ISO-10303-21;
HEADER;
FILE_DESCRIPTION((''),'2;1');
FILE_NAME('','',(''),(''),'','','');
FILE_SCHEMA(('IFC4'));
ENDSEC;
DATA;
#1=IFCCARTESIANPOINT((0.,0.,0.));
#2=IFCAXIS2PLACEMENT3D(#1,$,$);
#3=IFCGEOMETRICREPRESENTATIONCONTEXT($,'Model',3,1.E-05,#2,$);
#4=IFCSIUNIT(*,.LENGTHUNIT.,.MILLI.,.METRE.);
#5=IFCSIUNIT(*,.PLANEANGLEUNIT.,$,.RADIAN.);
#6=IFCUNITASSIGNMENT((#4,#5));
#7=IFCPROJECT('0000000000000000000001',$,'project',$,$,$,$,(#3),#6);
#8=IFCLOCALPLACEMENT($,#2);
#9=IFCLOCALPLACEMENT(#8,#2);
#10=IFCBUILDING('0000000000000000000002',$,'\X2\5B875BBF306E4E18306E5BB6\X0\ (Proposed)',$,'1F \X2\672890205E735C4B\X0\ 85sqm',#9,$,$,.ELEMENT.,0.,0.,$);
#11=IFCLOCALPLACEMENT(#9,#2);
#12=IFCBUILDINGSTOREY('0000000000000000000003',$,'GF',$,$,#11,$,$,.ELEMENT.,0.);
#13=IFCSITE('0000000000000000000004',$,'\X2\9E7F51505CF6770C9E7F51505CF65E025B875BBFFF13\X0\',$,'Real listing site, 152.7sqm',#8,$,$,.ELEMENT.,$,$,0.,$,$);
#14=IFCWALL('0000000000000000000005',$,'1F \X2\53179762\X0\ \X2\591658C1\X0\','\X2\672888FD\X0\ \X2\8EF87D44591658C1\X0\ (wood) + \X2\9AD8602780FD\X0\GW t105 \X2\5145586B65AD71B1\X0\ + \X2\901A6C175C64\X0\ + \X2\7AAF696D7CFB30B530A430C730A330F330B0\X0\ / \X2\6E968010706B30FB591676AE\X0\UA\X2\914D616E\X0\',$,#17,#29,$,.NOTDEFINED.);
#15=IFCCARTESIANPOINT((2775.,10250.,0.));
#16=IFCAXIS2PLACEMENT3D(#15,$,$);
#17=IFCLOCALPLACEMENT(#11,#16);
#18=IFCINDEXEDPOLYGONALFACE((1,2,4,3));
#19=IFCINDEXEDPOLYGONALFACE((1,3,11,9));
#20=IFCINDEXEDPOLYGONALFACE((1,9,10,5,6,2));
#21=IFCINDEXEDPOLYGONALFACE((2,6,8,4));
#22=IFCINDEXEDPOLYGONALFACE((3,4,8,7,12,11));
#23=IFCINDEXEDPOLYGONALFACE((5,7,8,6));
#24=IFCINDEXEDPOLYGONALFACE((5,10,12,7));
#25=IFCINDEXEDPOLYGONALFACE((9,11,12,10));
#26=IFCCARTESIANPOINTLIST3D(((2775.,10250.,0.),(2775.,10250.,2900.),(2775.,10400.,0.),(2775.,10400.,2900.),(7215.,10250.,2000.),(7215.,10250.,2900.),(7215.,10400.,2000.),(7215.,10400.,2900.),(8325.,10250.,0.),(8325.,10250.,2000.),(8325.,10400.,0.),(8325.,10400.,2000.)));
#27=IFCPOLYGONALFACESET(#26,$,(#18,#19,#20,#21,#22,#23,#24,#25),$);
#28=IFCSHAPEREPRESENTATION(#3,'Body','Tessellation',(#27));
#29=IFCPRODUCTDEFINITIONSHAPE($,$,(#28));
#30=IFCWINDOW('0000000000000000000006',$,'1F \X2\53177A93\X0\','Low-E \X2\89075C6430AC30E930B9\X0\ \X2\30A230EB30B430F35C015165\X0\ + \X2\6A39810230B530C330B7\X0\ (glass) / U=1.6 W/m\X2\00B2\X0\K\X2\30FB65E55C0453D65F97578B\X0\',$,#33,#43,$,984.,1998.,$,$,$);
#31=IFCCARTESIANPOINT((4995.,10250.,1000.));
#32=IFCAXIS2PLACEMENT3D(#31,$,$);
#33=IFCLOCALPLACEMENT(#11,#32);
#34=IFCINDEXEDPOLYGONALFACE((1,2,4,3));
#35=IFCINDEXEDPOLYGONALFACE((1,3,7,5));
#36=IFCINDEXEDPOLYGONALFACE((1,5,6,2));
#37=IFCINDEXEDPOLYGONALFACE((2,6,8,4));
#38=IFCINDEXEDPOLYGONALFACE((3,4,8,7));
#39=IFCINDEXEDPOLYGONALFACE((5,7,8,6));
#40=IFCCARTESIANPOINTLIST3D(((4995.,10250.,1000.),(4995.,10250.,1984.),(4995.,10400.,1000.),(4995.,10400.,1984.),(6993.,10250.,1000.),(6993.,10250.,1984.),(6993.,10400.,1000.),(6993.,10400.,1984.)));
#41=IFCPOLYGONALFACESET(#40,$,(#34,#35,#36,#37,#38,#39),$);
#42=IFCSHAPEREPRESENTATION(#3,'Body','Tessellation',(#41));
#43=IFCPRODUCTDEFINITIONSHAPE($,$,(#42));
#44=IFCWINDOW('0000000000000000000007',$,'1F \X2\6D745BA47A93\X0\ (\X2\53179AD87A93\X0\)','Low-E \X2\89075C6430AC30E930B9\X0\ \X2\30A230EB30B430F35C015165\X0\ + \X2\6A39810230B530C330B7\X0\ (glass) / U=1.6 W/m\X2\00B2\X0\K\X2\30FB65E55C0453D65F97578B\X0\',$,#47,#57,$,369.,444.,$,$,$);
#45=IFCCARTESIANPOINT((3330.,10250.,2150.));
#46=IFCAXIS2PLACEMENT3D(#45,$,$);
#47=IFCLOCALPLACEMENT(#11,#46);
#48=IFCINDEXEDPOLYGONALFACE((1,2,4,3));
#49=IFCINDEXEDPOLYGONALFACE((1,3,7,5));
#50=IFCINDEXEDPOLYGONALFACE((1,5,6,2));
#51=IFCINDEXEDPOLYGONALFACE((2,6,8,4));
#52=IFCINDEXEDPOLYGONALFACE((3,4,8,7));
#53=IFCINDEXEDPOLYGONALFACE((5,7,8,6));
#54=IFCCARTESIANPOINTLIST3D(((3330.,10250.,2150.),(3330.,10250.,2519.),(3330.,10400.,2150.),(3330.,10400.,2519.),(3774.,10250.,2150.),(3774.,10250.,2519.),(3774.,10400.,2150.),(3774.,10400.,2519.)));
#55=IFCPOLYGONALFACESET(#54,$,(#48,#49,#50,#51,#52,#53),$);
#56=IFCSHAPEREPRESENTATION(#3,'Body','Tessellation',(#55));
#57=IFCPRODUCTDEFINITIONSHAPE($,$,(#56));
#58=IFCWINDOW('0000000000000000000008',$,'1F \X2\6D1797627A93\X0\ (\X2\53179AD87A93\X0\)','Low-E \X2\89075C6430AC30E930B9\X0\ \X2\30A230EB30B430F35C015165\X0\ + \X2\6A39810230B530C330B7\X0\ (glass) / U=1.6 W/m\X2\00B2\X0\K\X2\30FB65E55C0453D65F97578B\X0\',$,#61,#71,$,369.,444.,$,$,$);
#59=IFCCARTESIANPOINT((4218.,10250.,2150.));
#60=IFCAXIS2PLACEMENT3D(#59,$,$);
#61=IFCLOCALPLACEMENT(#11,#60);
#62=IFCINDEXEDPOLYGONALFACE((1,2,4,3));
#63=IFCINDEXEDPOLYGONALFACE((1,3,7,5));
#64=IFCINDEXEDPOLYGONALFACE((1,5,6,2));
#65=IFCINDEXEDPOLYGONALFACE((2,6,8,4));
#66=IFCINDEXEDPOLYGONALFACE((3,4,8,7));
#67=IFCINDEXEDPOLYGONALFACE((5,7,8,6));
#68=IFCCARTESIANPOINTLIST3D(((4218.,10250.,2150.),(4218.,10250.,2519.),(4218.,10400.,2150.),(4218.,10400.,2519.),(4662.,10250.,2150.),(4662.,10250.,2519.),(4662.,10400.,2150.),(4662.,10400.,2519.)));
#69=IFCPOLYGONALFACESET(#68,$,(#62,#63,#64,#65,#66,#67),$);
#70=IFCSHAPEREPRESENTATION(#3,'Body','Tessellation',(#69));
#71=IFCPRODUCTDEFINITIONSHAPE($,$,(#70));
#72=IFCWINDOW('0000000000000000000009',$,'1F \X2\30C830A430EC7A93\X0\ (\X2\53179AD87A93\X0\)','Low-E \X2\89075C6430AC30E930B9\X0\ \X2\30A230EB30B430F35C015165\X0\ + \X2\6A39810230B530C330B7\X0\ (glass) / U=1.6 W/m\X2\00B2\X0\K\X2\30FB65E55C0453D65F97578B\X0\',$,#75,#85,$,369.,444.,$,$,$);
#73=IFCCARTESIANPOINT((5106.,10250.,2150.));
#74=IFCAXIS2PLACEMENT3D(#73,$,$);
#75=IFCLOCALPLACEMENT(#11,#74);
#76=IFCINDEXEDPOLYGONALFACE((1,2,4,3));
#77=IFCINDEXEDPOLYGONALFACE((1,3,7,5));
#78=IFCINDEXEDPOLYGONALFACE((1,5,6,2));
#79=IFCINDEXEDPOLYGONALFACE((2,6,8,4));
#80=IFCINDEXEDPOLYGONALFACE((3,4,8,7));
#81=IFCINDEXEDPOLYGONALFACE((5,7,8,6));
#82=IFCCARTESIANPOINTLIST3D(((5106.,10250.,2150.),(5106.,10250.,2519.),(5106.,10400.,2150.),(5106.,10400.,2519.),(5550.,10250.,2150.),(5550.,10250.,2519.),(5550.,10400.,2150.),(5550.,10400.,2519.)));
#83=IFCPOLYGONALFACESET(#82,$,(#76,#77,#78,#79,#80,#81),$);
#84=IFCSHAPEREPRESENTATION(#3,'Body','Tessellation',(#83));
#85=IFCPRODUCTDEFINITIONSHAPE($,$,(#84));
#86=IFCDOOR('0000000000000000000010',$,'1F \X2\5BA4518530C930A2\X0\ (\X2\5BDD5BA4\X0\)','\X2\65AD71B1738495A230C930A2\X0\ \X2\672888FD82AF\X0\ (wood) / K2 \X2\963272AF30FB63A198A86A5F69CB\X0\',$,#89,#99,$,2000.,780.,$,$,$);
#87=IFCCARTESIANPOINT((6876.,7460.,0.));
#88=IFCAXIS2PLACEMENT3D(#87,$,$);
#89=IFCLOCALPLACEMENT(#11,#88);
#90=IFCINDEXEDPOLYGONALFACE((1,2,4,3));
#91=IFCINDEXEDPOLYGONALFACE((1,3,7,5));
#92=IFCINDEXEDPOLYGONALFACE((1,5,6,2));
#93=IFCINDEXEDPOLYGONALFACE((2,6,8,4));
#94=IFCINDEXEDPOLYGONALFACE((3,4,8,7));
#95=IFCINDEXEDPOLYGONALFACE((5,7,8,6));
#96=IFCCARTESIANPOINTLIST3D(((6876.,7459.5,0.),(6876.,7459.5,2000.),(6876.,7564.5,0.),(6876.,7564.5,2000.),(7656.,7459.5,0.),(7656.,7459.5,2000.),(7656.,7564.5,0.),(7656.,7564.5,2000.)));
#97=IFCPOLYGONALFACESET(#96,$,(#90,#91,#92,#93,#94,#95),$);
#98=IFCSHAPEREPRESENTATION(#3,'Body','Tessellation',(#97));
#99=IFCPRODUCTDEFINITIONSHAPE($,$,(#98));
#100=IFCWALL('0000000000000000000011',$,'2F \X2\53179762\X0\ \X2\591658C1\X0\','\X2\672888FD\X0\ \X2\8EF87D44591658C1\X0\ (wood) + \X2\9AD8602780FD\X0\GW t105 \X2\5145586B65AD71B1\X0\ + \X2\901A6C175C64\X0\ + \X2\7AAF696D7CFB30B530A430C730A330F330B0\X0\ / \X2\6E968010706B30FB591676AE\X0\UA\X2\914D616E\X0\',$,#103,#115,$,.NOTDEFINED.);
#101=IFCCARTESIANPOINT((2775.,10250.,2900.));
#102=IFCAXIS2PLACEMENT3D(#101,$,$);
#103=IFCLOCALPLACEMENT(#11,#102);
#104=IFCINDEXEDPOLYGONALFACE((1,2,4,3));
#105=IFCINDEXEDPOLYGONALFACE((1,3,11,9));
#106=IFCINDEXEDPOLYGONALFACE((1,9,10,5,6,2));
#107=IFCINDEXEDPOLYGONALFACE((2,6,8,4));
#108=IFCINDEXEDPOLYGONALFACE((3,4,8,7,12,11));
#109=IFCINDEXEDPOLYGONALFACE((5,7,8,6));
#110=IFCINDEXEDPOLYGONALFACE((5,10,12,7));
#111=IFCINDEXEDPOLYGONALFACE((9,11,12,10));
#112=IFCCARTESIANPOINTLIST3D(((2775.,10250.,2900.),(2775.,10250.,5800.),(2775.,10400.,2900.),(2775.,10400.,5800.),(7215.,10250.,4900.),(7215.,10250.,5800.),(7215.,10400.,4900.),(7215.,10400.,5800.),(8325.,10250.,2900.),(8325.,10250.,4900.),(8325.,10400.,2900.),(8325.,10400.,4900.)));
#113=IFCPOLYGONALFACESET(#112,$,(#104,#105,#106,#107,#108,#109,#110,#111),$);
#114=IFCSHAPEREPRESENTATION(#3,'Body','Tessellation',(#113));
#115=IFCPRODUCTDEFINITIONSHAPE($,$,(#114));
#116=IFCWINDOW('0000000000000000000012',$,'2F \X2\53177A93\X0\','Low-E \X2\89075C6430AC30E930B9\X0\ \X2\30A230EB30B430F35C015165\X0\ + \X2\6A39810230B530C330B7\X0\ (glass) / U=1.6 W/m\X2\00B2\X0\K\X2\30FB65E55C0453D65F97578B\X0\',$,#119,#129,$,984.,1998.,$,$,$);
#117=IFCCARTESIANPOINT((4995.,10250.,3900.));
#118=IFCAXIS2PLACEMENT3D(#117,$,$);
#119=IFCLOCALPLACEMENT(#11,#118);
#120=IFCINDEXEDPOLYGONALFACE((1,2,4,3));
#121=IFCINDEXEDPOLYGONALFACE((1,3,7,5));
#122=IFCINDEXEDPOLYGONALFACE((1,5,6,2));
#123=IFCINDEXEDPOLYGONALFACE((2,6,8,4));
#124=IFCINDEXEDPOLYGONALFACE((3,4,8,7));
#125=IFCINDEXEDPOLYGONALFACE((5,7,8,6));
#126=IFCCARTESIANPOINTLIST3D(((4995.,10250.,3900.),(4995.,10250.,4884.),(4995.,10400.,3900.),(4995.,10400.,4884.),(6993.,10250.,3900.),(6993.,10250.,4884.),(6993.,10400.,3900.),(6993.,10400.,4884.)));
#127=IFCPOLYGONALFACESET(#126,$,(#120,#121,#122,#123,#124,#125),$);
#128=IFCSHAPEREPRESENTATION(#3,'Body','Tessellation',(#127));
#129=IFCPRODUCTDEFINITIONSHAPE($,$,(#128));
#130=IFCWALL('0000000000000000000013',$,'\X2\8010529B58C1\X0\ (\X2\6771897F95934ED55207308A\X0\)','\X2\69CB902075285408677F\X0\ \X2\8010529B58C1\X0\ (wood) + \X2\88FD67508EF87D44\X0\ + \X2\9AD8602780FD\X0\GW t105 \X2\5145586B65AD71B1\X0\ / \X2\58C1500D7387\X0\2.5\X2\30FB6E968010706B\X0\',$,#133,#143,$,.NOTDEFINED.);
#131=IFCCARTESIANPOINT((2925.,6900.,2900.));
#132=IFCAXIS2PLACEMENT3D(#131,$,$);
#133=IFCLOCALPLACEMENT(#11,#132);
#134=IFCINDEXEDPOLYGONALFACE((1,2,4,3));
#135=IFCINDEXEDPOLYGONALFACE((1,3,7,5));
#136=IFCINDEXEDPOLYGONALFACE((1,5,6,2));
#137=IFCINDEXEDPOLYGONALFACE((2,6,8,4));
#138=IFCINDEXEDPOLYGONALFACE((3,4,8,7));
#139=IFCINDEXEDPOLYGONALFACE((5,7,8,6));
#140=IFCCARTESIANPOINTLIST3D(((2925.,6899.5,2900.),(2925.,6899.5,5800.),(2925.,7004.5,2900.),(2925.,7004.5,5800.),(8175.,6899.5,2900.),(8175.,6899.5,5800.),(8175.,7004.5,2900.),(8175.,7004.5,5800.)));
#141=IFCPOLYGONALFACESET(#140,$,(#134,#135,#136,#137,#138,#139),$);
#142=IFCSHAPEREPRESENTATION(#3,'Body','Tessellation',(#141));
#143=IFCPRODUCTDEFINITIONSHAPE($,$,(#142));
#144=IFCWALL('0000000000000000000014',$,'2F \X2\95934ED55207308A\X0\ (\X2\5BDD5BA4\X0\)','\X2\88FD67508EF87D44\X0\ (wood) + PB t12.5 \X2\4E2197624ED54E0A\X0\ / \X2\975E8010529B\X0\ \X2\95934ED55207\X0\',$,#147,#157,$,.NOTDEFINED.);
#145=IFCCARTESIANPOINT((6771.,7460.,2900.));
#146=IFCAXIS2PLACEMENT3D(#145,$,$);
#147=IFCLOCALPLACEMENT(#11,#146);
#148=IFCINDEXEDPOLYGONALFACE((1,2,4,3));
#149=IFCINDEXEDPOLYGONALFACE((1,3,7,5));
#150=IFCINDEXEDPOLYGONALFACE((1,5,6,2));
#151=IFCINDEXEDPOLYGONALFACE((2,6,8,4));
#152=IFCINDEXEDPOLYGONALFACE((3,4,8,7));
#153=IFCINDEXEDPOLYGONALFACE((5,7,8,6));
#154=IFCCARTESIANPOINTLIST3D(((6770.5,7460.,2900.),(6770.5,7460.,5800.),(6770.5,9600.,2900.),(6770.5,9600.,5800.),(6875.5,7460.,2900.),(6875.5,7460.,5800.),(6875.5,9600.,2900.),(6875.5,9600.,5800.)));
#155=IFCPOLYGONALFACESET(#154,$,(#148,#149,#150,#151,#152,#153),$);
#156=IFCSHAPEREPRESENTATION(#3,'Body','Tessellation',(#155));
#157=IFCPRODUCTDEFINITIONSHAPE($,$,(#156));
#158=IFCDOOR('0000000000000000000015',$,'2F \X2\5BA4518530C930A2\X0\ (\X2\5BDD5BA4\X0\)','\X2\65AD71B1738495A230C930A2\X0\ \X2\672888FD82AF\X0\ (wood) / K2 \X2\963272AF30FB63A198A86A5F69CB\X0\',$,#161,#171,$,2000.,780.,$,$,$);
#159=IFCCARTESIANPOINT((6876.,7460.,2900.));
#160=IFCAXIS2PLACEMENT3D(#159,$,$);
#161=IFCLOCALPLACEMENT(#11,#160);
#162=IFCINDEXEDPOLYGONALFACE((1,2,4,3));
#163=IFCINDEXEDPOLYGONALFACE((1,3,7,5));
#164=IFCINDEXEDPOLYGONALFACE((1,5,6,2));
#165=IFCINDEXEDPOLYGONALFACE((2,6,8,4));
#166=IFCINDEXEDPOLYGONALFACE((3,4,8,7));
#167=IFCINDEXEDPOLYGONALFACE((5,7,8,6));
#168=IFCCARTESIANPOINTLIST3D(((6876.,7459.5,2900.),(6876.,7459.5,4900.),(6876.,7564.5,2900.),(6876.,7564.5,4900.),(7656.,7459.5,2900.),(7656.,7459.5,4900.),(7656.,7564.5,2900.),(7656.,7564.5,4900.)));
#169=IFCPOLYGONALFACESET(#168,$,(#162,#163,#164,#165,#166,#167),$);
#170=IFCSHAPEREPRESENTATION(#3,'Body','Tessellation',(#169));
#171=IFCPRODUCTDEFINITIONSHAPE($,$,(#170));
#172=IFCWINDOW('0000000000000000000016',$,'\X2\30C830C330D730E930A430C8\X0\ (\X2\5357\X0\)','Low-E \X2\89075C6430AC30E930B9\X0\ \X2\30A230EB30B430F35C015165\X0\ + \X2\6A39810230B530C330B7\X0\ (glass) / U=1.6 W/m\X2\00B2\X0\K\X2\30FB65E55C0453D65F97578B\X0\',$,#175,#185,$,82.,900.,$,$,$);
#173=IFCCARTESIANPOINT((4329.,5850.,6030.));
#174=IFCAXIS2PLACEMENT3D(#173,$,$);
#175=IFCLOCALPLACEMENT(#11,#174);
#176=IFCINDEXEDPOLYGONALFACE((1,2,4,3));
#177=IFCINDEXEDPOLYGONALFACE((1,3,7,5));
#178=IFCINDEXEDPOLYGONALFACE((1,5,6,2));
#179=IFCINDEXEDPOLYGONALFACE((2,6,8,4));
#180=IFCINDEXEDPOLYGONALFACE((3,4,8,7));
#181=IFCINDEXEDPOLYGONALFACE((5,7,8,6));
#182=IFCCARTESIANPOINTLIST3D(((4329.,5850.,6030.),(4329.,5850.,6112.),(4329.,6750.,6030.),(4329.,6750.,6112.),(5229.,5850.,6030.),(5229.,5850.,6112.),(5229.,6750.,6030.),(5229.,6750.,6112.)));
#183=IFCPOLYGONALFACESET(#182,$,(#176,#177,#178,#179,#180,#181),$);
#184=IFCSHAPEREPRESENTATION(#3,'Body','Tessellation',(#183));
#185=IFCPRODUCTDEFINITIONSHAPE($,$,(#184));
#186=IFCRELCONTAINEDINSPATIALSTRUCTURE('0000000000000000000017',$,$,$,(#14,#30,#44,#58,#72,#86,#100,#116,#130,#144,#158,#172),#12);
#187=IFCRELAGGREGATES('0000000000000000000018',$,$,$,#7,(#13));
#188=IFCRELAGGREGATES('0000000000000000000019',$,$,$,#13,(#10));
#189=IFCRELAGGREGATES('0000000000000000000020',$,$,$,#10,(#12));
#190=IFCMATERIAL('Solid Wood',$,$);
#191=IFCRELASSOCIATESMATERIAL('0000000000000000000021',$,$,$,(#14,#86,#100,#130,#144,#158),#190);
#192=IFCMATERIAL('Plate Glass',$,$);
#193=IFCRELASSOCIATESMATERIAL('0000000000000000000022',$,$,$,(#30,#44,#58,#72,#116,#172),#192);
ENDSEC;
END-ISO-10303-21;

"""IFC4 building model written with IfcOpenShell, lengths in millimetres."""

from ifc_helpers import new_model, si_unit, frame, frame_2d, origin, place, context, project, spatial, rectangle, extrude, material, element, fill, save


model = new_model("IFC4")

# Units and contexts
model_context = context("Model", 3, precision=1e-05, world=origin())
ifc_project = project(units=[si_unit("LENGTHUNIT", "METRE", prefix="MILLI"), si_unit("PLANEANGLEUNIT", "RADIAN")], contexts=[model_context])

# Site, building, storey
site_placement = place(None, origin())
site = spatial("IfcSite", under=ifc_project, at=site_placement, Name="鹿児島県鹿児島市宇宿３", ObjectType="Real listing site, 152.7sqm", CompositionType="ELEMENT", RefElevation=0.0)
building_placement = place(site_placement, origin())
building = spatial("IfcBuilding", under=site, at=building_placement, Name="宇宿の丘の家 (Proposed)", ObjectType="1F 木造平屋 85sqm", CompositionType="ELEMENT", ElevationOfRefHeight=0.0, ElevationOfTerrain=0.0)
storey_placement = place(building_placement, origin())
storey = spatial("IfcBuildingStorey", under=building, at=storey_placement, Name="GF", CompositionType="ELEMENT", Elevation=0.0)

# Wall, openings, windows
ifc_material_1 = material(Name="Solid Wood")
wall_1_placement = place(storey_placement, frame((2775.0, 10250.0, 0.0)))
wall_1 = element("IfcWall", 1, at=wall_1_placement, inside=storey, material=ifc_material_1, Name="1F 北面 外壁", Description="木製 軸組外壁 (wood) + 高性能GW t105 充填断熱 + 通気層 + 窯業系サイディング / 準耐火・外皮UA配慮", PredefinedType="NOTDEFINED", context=model_context, shape_type="SweptSolid", body=[
    extrude(rectangle(XDim=5550.0, YDim=150.0, at=frame_2d((2775.0, 75.0))), frame((2775.0, 10250.0, 0.0)), (0.0, 0.0, 1.0), 2900.0),
])
opening_1_placement = place(storey_placement, frame((4995.0, 10250.0, 1000.0)))
opening_1 = element("IfcOpeningElement", 2, at=opening_1_placement, cuts=wall_1, PredefinedType="NOTDEFINED", context=model_context, shape_type="SweptSolid", body=[
    extrude(rectangle(XDim=1998.0, YDim=150.0, at=frame_2d((999.0, 75.0))), frame((4995.0, 10250.0, 1000.0)), (0.0, 0.0, 1.0), 984.0),
])
opening_2_placement = place(storey_placement, frame((3330.0, 10250.0, 2150.0)))
opening_2 = element("IfcOpeningElement", 3, at=opening_2_placement, cuts=wall_1, PredefinedType="NOTDEFINED", context=model_context, shape_type="SweptSolid", body=[
    extrude(rectangle(XDim=444.0, YDim=150.0, at=frame_2d((222.0, 75.0))), frame((3330.0, 10250.0, 2150.0)), (0.0, 0.0, 1.0), 369.0),
])
opening_3_placement = place(storey_placement, frame((4218.0, 10250.0, 2150.0)))
opening_3 = element("IfcOpeningElement", 4, at=opening_3_placement, cuts=wall_1, PredefinedType="NOTDEFINED", context=model_context, shape_type="SweptSolid", body=[
    extrude(rectangle(XDim=444.0, YDim=150.0, at=frame_2d((222.0, 75.0))), frame((4218.0, 10250.0, 2150.0)), (0.0, 0.0, 1.0), 369.0),
])
opening_4_placement = place(storey_placement, frame((5106.0, 10250.0, 2150.0)))
opening_4 = element("IfcOpeningElement", 5, at=opening_4_placement, cuts=wall_1, PredefinedType="NOTDEFINED", context=model_context, shape_type="SweptSolid", body=[
    extrude(rectangle(XDim=444.0, YDim=150.0, at=frame_2d((222.0, 75.0))), frame((5106.0, 10250.0, 2150.0)), (0.0, 0.0, 1.0), 369.0),
])
ifc_material_2 = material(Name="Plate Glass")
window_1_placement = place(storey_placement, frame((4995.0, 10250.0, 1000.0)))
window_1 = element("IfcWindow", 6, at=window_1_placement, inside=storey, material=ifc_material_2, Name="1F 北窓", Description="Low-E 複層ガラス アルゴン封入 + 樹脂サッシ (glass) / U=1.6 W/m²K・日射取得型", OverallHeight=984.0, OverallWidth=1998.0, context=model_context, shape_type="SweptSolid", body=[
    extrude(rectangle(XDim=1998.0, YDim=150.0, at=frame_2d((999.0, 75.0))), frame((4995.0, 10250.0, 1000.0)), (0.0, 0.0, 1.0), 984.0),
])
fill(opening_1, window_1)
window_2_placement = place(storey_placement, frame((3330.0, 10250.0, 2150.0)))
window_2 = element("IfcWindow", 7, at=window_2_placement, inside=storey, material=ifc_material_2, Name="1F 浴室窓 (北高窓)", Description="Low-E 複層ガラス アルゴン封入 + 樹脂サッシ (glass) / U=1.6 W/m²K・日射取得型", OverallHeight=369.0, OverallWidth=444.0, context=model_context, shape_type="SweptSolid", body=[
    extrude(rectangle(XDim=444.0, YDim=150.0, at=frame_2d((222.0, 75.0))), frame((3330.0, 10250.0, 2150.0)), (0.0, 0.0, 1.0), 369.0),
])
fill(opening_2, window_2)
window_3_placement = place(storey_placement, frame((4218.0, 10250.0, 2150.0)))
window_3 = element("IfcWindow", 8, at=window_3_placement, inside=storey, material=ifc_material_2, Name="1F 洗面窓 (北高窓)", Description="Low-E 複層ガラス アルゴン封入 + 樹脂サッシ (glass) / U=1.6 W/m²K・日射取得型", OverallHeight=369.0, OverallWidth=444.0, context=model_context, shape_type="SweptSolid", body=[
    extrude(rectangle(XDim=444.0, YDim=150.0, at=frame_2d((222.0, 75.0))), frame((4218.0, 10250.0, 2150.0)), (0.0, 0.0, 1.0), 369.0),
])
fill(opening_3, window_3)
window_4_placement = place(storey_placement, frame((5106.0, 10250.0, 2150.0)))
window_4 = element("IfcWindow", 9, at=window_4_placement, inside=storey, material=ifc_material_2, Name="1F トイレ窓 (北高窓)", Description="Low-E 複層ガラス アルゴン封入 + 樹脂サッシ (glass) / U=1.6 W/m²K・日射取得型", OverallHeight=369.0, OverallWidth=444.0, context=model_context, shape_type="SweptSolid", body=[
    extrude(rectangle(XDim=444.0, YDim=150.0, at=frame_2d((222.0, 75.0))), frame((5106.0, 10250.0, 2150.0)), (0.0, 0.0, 1.0), 369.0),
])
fill(opening_4, window_4)

# Door
door_1_placement = place(storey_placement, frame((6876.0, 7460.0, 0.0)))
element("IfcDoor", 10, at=door_1_placement, inside=storey, material=ifc_material_1, Name="1F 室内ドア (寝室)", Description="断熱玄関ドア 木製芯 (wood) / K2 防犯・採風機構", OverallHeight=2000.0, OverallWidth=780.0, context=model_context, shape_type="SweptSolid", body=[
    extrude(rectangle(XDim=780.0, YDim=105.0, at=frame_2d((390.0, 52.0))), frame((6876.0, 7460.0, 0.0)), (0.0, 0.0, 1.0), 2000.0),
])

# Wall, opening, window
wall_2_placement = place(storey_placement, frame((2775.0, 10250.0, 2900.0)))
wall_2 = element("IfcWall", 11, at=wall_2_placement, inside=storey, material=ifc_material_1, Name="2F 北面 外壁", Description="木製 軸組外壁 (wood) + 高性能GW t105 充填断熱 + 通気層 + 窯業系サイディング / 準耐火・外皮UA配慮", PredefinedType="NOTDEFINED", context=model_context, shape_type="SweptSolid", body=[
    extrude(rectangle(XDim=5550.0, YDim=150.0, at=frame_2d((2775.0, 75.0))), frame((2775.0, 10250.0, 2900.0)), (0.0, 0.0, 1.0), 2900.0),
])
opening_5_placement = place(storey_placement, frame((4995.0, 10250.0, 3900.0)))
opening_5 = element("IfcOpeningElement", 12, at=opening_5_placement, cuts=wall_2, PredefinedType="NOTDEFINED", context=model_context, shape_type="SweptSolid", body=[
    extrude(rectangle(XDim=1998.0, YDim=150.0, at=frame_2d((999.0, 75.0))), frame((4995.0, 10250.0, 3900.0)), (0.0, 0.0, 1.0), 984.0),
])
window_5_placement = place(storey_placement, frame((4995.0, 10250.0, 3900.0)))
window_5 = element("IfcWindow", 13, at=window_5_placement, inside=storey, material=ifc_material_2, Name="2F 北窓", Description="Low-E 複層ガラス アルゴン封入 + 樹脂サッシ (glass) / U=1.6 W/m²K・日射取得型", OverallHeight=984.0, OverallWidth=1998.0, context=model_context, shape_type="SweptSolid", body=[
    extrude(rectangle(XDim=1998.0, YDim=150.0, at=frame_2d((999.0, 75.0))), frame((4995.0, 10250.0, 3900.0)), (0.0, 0.0, 1.0), 984.0),
])
fill(opening_5, window_5)

# Walls
wall_3_placement = place(storey_placement, frame((2925.0, 6900.0, 2900.0)))
element("IfcWall", 14, at=wall_3_placement, inside=storey, material=ifc_material_1, Name="耐力壁 (東西間仕切り)", Description="構造用合板 耐力壁 (wood) + 製材軸組 + 高性能GW t105 充填断熱 / 壁倍率2.5・準耐火", PredefinedType="NOTDEFINED", context=model_context, shape_type="SweptSolid", body=[
    extrude(rectangle(XDim=5250.0, YDim=105.0, at=frame_2d((2625.0, 52.0))), frame((2925.0, 6900.0, 2900.0)), (0.0, 0.0, 1.0), 2900.0),
])
wall_4_placement = place(storey_placement, frame((6771.0, 7460.0, 2900.0)))
element("IfcWall", 15, at=wall_4_placement, inside=storey, material=ifc_material_1, Name="2F 間仕切り (寝室)", Description="製材軸組 (wood) + PB t12.5 両面仕上 / 非耐力 間仕切", PredefinedType="NOTDEFINED", context=model_context, shape_type="SweptSolid", body=[
    extrude(rectangle(XDim=105.0, YDim=2140.0, at=frame_2d((52.0, 1070.0))), frame((6771.0, 7460.0, 2900.0)), (0.0, 0.0, 1.0), 2900.0),
])

# Door
door_2_placement = place(storey_placement, frame((6876.0, 7460.0, 2900.0)))
element("IfcDoor", 16, at=door_2_placement, inside=storey, material=ifc_material_1, Name="2F 室内ドア (寝室)", Description="断熱玄関ドア 木製芯 (wood) / K2 防犯・採風機構", OverallHeight=2000.0, OverallWidth=780.0, context=model_context, shape_type="SweptSolid", body=[
    extrude(rectangle(XDim=780.0, YDim=105.0, at=frame_2d((390.0, 52.0))), frame((6876.0, 7460.0, 2900.0)), (0.0, 0.0, 1.0), 2000.0),
])

# Window
window_6_placement = place(storey_placement, frame((4329.0, 5850.0, 6030.0)))
element("IfcWindow", 17, at=window_6_placement, inside=storey, material=ifc_material_2, Name="トップライト (南)", Description="Low-E 複層ガラス アルゴン封入 + 樹脂サッシ (glass) / U=1.6 W/m²K・日射取得型", OverallHeight=82.0, OverallWidth=900.0, context=model_context, shape_type="SweptSolid", body=[
    extrude(rectangle(XDim=900.0, YDim=900.0, at=frame_2d((450.0, 450.0))), frame((4329.0, 5850.0, 6030.0)), (0.0, 0.0, 1.0), 82.0),
])

save(model, "model.ifc")
